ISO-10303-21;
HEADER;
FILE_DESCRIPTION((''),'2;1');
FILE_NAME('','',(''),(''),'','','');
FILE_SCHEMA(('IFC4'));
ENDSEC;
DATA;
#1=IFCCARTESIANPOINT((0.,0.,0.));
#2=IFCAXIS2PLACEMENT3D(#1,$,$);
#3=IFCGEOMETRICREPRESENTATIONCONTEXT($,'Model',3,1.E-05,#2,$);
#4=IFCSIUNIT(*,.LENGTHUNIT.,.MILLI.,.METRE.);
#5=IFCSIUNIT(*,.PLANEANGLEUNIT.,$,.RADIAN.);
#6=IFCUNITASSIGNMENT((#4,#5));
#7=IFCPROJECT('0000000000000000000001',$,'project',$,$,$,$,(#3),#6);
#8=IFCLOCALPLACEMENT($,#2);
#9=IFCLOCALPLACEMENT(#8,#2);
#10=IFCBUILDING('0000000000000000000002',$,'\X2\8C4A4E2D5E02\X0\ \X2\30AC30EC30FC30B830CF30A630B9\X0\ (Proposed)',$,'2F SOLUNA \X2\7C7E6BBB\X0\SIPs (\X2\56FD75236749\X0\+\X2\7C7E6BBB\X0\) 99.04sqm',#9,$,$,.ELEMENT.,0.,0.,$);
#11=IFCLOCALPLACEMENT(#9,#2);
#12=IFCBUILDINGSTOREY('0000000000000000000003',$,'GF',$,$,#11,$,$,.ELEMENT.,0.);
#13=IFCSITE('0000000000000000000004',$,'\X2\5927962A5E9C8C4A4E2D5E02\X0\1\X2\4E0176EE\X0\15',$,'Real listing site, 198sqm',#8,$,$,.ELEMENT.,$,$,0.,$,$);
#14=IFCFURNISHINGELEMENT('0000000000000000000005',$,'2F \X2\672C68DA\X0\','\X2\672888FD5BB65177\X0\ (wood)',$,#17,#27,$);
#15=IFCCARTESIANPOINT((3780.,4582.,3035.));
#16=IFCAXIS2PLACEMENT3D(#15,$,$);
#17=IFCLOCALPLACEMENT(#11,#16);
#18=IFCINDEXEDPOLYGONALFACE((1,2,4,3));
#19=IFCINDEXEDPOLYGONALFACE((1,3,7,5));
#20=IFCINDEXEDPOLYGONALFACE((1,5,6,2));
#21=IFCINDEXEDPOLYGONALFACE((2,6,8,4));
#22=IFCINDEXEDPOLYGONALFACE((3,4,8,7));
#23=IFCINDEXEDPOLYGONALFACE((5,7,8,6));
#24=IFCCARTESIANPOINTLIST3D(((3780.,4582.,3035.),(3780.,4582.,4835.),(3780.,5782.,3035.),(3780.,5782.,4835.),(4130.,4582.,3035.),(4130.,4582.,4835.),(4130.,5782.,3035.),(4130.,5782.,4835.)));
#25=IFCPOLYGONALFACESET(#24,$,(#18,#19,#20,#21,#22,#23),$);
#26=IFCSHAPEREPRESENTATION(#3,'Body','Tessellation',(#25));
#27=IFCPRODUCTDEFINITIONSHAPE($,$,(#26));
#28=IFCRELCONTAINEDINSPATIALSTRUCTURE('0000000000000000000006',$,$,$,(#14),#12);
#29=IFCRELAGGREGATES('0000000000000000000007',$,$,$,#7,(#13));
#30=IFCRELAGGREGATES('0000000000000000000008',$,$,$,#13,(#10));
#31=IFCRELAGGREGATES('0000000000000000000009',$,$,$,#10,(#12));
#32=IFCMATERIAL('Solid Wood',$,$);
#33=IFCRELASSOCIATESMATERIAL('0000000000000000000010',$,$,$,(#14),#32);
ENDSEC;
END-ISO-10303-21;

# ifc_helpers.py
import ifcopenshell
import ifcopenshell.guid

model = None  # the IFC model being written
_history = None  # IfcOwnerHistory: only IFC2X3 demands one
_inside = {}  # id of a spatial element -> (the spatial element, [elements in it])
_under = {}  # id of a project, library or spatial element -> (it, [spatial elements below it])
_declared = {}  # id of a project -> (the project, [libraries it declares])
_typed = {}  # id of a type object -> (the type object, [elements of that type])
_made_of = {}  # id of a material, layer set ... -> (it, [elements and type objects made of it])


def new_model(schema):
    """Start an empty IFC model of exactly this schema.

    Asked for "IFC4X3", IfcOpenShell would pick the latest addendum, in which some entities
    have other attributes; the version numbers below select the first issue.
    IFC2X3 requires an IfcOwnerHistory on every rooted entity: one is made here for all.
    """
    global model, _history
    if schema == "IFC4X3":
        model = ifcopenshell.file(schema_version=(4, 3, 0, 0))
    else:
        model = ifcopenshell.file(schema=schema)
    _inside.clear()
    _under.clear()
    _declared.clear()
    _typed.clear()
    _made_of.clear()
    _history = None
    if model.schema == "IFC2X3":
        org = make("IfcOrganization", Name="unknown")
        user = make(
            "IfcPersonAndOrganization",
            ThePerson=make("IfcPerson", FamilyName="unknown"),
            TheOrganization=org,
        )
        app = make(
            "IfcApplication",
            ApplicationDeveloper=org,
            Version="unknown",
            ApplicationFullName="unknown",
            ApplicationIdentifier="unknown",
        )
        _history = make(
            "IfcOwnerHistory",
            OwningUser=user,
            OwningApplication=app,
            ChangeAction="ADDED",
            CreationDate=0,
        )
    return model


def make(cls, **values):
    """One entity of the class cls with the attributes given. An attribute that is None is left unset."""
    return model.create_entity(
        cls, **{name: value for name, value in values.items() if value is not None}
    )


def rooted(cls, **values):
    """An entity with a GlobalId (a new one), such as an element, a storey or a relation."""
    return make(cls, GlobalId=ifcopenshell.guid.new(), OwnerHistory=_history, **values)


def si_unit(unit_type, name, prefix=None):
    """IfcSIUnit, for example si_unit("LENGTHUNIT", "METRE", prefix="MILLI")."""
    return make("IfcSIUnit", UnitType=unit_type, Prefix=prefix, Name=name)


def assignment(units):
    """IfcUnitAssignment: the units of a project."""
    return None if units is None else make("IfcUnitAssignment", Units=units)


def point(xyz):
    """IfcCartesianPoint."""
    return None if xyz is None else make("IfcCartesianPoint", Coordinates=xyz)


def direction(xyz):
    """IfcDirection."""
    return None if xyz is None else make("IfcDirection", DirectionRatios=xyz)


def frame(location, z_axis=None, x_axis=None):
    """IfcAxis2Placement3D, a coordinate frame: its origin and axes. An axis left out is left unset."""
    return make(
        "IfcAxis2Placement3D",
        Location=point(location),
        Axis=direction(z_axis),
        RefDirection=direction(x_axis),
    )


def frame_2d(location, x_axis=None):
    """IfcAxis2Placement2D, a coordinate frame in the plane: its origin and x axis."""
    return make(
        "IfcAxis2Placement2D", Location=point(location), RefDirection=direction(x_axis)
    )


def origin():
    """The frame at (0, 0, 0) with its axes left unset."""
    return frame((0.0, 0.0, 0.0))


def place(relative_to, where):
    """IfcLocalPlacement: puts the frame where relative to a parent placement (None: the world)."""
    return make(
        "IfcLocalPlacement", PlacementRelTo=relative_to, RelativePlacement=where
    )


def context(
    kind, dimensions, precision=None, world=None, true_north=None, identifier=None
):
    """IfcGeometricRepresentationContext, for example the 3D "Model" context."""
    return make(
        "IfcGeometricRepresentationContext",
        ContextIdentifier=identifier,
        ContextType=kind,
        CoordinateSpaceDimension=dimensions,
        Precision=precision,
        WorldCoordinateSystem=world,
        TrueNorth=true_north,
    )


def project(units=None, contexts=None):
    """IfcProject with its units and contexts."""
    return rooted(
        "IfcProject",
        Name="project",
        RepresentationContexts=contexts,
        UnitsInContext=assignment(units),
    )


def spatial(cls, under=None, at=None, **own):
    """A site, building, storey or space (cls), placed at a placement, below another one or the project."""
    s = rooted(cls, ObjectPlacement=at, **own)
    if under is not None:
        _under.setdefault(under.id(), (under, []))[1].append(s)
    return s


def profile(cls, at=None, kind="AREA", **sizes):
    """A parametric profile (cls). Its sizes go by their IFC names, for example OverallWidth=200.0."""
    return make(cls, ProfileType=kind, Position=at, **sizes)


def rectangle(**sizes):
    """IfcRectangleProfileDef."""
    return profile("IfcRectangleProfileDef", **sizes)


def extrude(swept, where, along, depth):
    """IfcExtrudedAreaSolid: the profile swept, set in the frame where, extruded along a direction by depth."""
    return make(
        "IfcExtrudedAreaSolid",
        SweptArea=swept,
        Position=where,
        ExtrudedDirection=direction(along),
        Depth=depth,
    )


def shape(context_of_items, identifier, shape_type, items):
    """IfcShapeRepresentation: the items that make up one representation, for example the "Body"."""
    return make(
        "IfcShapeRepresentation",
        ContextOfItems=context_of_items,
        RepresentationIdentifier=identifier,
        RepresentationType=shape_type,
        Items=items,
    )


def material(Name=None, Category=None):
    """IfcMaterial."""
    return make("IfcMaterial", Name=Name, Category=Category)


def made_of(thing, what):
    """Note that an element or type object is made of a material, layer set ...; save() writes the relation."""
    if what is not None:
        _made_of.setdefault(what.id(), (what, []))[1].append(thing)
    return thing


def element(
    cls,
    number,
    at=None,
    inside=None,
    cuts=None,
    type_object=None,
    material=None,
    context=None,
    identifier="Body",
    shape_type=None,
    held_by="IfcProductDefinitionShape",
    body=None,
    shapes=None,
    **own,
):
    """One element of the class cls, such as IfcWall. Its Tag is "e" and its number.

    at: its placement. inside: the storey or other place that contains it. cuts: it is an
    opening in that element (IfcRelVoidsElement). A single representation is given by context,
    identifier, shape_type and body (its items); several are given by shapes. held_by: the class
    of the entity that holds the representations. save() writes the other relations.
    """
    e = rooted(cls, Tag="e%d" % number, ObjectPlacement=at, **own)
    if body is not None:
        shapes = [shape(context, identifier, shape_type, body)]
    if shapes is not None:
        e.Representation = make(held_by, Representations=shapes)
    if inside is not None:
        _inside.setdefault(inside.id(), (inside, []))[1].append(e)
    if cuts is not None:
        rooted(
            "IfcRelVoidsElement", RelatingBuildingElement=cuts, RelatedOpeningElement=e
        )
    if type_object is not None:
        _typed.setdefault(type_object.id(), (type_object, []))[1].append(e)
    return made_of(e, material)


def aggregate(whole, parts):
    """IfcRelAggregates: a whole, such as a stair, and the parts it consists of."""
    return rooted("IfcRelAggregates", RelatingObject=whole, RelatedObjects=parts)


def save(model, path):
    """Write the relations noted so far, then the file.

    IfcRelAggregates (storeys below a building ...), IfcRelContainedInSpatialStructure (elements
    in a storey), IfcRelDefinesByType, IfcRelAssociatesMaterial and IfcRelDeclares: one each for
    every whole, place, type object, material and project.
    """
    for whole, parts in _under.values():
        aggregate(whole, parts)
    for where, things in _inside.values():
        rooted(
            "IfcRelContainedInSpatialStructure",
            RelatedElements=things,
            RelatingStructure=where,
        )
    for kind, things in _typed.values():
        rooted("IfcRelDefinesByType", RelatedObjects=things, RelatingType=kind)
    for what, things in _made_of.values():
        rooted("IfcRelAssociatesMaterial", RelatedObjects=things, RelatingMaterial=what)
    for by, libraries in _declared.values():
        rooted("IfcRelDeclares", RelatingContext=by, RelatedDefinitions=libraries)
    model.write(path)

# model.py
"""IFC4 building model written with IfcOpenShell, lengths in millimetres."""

from ifc_helpers import new_model, si_unit, frame, frame_2d, origin, place, context, project, spatial, rectangle, extrude, material, element, save


model = new_model("IFC4")

# Units and contexts
model_context = context("Model", 3, precision=1e-05, world=origin())
ifc_project = project(units=[si_unit("LENGTHUNIT", "METRE", prefix="MILLI"), si_unit("PLANEANGLEUNIT", "RADIAN")], contexts=[model_context])

# Site, building, storey
site_placement = place(None, origin())
site = spatial("IfcSite", under=ifc_project, at=site_placement, Name="大阪府豊中市1丁目15", ObjectType="Real listing site, 198sqm", CompositionType="ELEMENT", RefElevation=0.0)
building_placement = place(site_placement, origin())
building = spatial("IfcBuilding", under=site, at=building_placement, Name="豊中市 ガレージハウス (Proposed)", ObjectType="2F SOLUNA 籾殻SIPs (国産杉+籾殻) 99.04sqm", CompositionType="ELEMENT", ElevationOfRefHeight=0.0, ElevationOfTerrain=0.0)
storey_placement = place(building_placement, origin())
storey = spatial("IfcBuildingStorey", under=building, at=storey_placement, Name="GF", CompositionType="ELEMENT", Elevation=0.0)

# Shared definitions
ifc_material_1 = material(Name="Solid Wood")

# Furnishing element
furnishing_placement = place(storey_placement, frame((3780.0, 4582.0, 3035.0)))
element("IfcFurnishingElement", 1, at=furnishing_placement, inside=storey, material=ifc_material_1, Name="2F 本棚", Description="木製家具 (wood)", context=model_context, shape_type="SweptSolid", body=[
    extrude(rectangle(XDim=350.0, YDim=1200.0, at=frame_2d((175.0, 600.0))), frame((3780.0, 4582.0, 3035.0)), (0.0, 0.0, 1.0), 1800.0),
])

save(model, "model.ifc")
